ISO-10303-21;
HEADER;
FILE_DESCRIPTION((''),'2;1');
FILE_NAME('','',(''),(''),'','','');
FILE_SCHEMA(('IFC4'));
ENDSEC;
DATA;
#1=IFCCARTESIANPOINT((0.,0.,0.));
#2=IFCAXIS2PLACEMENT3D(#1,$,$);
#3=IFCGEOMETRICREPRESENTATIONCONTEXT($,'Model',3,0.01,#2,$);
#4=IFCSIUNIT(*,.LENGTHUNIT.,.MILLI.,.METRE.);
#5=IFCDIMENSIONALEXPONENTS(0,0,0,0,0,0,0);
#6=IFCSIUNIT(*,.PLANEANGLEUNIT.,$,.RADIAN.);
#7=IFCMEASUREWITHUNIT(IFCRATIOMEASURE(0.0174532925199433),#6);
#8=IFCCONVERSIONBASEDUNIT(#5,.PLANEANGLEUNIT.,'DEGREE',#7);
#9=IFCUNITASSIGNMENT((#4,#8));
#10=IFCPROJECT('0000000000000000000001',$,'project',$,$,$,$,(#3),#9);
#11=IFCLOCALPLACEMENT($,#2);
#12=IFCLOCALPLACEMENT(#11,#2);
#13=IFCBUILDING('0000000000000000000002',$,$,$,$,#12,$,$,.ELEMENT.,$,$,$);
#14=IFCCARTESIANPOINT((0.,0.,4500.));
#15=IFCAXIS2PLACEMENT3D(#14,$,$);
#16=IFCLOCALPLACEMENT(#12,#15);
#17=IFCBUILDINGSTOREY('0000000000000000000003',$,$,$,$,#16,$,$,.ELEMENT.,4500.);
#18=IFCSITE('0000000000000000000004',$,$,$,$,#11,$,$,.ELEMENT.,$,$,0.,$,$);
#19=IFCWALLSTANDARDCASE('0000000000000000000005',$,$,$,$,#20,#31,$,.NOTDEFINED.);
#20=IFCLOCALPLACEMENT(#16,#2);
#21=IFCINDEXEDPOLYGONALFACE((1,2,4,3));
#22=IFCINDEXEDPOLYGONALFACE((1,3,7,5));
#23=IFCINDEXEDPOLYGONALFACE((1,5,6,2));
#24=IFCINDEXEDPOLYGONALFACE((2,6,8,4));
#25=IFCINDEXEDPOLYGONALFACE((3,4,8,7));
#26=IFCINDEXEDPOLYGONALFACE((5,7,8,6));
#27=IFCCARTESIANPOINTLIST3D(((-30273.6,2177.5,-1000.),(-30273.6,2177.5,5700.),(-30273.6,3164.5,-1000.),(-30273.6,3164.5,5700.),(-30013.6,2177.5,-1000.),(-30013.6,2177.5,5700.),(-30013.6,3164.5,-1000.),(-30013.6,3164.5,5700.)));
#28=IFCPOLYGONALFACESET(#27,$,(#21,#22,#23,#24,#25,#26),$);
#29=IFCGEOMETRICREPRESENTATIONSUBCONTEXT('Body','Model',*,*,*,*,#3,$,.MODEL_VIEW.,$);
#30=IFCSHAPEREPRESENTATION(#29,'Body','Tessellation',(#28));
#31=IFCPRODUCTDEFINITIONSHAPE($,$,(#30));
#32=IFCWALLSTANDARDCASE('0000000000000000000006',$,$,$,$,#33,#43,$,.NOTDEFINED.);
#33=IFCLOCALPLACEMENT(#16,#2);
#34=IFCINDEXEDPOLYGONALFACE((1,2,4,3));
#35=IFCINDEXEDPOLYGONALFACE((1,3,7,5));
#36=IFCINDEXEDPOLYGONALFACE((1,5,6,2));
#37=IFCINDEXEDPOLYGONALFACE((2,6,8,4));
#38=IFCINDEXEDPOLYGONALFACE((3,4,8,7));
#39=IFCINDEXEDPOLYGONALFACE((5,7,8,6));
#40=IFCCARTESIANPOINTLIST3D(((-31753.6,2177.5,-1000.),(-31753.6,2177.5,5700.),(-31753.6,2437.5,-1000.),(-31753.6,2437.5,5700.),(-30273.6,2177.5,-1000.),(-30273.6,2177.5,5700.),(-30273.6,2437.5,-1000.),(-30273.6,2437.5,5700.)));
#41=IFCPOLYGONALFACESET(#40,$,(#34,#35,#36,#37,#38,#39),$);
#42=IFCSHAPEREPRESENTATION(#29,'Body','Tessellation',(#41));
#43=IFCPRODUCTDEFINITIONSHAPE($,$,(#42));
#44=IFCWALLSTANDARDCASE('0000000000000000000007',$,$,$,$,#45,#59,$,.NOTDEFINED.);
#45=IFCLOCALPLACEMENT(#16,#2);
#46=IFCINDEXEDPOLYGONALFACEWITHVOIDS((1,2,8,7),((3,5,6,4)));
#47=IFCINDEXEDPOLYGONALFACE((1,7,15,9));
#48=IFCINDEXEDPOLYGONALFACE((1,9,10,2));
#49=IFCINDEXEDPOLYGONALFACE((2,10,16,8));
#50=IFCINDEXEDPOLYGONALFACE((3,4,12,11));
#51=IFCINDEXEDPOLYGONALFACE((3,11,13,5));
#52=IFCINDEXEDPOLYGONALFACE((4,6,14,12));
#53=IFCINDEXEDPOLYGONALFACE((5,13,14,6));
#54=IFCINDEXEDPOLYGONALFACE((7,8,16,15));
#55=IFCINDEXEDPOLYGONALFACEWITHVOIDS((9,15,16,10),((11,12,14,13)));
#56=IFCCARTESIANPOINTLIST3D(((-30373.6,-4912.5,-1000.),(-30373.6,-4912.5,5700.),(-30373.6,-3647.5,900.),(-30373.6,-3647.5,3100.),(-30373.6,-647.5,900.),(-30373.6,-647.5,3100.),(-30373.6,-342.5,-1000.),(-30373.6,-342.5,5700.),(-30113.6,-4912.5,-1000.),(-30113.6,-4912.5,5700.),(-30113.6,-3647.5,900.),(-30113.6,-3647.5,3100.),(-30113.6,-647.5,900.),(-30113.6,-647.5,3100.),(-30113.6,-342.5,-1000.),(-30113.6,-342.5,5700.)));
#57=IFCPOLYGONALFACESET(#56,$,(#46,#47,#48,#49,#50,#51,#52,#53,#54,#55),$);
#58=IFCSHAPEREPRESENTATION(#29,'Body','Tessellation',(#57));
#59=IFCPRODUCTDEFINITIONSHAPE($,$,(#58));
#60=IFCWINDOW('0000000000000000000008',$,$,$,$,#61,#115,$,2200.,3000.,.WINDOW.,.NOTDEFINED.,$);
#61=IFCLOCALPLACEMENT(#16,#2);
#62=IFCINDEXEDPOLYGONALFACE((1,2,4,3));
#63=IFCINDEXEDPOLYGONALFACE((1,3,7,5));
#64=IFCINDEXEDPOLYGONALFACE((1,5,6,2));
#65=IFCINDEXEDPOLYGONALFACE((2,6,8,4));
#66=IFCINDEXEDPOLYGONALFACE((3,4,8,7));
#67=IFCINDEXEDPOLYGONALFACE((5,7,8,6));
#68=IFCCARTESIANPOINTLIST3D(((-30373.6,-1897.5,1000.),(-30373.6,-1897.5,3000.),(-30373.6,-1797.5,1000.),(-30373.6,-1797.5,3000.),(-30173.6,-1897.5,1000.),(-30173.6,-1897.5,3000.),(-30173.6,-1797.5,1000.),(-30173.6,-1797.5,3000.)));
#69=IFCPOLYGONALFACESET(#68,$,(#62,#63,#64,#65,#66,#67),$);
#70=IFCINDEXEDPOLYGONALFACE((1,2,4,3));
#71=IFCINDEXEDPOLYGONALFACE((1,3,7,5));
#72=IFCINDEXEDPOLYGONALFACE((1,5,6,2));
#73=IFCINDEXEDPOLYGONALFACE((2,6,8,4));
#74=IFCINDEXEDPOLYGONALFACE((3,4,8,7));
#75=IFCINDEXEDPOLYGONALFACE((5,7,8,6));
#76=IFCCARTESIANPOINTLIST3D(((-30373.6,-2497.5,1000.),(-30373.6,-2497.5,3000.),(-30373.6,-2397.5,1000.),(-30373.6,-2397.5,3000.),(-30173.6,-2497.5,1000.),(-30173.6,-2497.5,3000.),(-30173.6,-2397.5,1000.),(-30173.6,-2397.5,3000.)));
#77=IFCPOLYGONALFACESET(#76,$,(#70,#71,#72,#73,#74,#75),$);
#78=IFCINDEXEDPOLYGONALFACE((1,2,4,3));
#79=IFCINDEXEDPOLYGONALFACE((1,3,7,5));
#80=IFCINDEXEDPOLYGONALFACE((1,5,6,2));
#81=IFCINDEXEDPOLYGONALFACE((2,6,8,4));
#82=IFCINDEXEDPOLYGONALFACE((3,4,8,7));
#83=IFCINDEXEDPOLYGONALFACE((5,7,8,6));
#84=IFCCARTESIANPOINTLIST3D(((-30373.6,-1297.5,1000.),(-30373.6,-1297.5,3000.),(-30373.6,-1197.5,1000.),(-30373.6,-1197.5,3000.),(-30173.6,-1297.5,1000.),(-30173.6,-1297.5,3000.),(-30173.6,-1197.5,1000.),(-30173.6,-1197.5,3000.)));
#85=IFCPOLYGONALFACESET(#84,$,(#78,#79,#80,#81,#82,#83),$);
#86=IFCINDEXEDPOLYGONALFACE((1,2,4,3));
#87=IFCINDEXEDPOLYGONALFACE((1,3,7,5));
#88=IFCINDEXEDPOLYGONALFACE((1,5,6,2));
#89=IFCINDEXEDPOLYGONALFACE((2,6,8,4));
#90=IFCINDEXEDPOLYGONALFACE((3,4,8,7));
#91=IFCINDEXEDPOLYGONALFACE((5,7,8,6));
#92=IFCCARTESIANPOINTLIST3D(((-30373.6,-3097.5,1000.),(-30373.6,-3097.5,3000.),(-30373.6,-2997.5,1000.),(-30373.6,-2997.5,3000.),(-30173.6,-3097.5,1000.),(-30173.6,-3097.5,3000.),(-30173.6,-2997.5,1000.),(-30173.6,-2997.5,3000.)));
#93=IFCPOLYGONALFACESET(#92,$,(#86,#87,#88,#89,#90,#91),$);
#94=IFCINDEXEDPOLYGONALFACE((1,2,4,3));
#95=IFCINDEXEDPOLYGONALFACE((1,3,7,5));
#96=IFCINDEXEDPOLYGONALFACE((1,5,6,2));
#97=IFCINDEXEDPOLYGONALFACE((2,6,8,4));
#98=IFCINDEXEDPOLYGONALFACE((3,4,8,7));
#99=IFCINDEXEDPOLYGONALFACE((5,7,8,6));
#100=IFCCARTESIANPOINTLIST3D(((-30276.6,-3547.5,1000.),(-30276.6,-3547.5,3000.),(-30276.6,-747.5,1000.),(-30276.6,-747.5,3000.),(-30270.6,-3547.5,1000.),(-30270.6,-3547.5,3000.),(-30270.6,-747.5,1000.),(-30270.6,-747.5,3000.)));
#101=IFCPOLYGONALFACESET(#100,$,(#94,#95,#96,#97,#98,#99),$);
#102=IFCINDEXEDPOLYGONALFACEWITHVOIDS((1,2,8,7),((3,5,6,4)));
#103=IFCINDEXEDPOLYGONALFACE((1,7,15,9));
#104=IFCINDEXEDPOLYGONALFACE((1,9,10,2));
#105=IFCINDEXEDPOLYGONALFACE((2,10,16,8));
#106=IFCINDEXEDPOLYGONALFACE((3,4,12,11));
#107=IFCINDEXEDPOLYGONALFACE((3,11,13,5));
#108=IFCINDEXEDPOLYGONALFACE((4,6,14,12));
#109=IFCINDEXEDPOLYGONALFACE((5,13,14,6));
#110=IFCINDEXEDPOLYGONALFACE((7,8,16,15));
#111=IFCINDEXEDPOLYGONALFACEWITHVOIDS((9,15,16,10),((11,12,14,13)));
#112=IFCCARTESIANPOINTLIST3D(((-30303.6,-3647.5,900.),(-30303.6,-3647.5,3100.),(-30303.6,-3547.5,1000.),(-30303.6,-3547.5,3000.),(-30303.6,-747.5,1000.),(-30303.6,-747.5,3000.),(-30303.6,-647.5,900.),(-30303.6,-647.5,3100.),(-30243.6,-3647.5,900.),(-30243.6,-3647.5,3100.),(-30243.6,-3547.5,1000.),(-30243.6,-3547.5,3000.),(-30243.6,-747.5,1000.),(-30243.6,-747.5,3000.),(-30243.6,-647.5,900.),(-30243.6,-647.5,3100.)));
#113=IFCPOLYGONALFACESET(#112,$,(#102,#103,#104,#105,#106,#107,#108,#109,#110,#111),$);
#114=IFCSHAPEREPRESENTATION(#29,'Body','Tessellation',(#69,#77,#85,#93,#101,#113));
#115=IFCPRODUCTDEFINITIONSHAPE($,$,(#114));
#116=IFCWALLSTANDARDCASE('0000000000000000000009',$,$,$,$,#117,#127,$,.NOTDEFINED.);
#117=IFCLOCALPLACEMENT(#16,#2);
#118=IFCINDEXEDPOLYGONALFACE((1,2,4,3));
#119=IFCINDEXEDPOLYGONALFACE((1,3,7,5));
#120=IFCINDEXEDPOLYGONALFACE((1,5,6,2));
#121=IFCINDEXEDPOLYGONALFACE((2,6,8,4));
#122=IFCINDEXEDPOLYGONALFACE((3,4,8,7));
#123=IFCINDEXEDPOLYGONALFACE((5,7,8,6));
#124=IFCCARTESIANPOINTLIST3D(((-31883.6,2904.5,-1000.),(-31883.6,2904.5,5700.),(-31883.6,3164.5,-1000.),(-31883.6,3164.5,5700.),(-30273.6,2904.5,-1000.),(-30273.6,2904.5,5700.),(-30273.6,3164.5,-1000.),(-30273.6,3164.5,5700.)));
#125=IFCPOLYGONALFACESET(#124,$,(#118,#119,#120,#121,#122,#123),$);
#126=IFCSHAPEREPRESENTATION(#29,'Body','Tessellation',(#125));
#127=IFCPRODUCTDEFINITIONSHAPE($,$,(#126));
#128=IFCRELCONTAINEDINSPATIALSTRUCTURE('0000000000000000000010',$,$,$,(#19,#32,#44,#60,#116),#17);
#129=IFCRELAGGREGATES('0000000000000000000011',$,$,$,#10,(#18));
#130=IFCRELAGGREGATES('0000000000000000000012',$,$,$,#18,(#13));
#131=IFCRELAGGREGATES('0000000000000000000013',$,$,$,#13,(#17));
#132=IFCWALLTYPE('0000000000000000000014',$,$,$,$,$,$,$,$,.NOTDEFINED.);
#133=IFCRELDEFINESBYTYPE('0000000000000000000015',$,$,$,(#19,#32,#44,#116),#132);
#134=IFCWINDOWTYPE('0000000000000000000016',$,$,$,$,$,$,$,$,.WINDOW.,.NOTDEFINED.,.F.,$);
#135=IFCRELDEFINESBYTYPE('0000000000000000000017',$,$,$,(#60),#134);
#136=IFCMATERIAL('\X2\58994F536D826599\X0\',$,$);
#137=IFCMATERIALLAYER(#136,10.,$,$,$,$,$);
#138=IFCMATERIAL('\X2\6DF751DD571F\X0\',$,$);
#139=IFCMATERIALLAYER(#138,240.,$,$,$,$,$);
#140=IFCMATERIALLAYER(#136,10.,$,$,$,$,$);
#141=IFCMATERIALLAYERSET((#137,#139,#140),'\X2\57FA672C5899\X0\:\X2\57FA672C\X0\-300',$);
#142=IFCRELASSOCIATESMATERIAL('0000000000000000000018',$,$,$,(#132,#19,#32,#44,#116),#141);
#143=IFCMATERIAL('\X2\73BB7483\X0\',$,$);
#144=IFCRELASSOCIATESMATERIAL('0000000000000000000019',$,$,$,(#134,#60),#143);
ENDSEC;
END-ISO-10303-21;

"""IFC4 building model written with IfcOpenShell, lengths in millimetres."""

from ifc_helpers import new_model, entity, si_unit, converted_unit, frame, frame_2d, origin, origin_2d_with_axis, place, context, subcontext, project, spatial, polyline, rectangle, outline, extrude, source, transform, mapped, material, layer, layer_set, layer_usage, type_object, type_shapes, element, fill, save


model = new_model("IFC4")

# Units and contexts
model_context = context("Model", 3, precision=0.01, world=origin())
body_context = subcontext(model_context, "Body", "Model", "MODEL_VIEW")
ifc_project = project(units=[si_unit("LENGTHUNIT", "METRE", prefix="MILLI"), converted_unit("PLANEANGLEUNIT", "DEGREE", entity("IfcRatioMeasure", 0.0174532925199433), si_unit("PLANEANGLEUNIT", "RADIAN"), dimensions=[0, 0, 0, 0, 0, 0, 0])], contexts=[model_context])

# Site, building, storey
site_placement = place(None, origin())
site = spatial("IfcSite", under=ifc_project, at=site_placement, CompositionType="ELEMENT", RefElevation=0.0)
building_placement = place(site_placement, origin())
building = spatial("IfcBuilding", under=site, at=building_placement, CompositionType="ELEMENT")
storey_placement = place(building_placement, frame((0.0, 0.0, 4500.0)))
storey = spatial("IfcBuildingStorey", under=building, at=storey_placement, CompositionType="ELEMENT", Elevation=4500.0)

# Shared definitions
ifc_material_1 = material(Name="混凝土")

# Shared definitions
ifc_material_2 = material(Name="墙体涂料")
ifc_layer_1 = layer(ifc_material_2, 10.0)
ifc_layer_2 = layer(ifc_material_1, 240.0)
ifc_layer_3 = layer(ifc_material_2, 10.0)
ifc_layer_set_1 = layer_set([ifc_layer_1, ifc_layer_2, ifc_layer_3], Name="基本墙:基本-300")
wall_type = type_object("IfcWallType", PredefinedType="NOTDEFINED", material=ifc_layer_set_1)
ifc_material_3 = material(Name="玻璃")

# Walls
ifc_layer_usage_1 = layer_usage(ifc_layer_set_1, "AXIS2", "NEGATIVE", 130.0)
wall_1_placement = place(storey_placement, frame((-30143.6, 3164.5, -1000.0), z_axis=(0.0, 0.0, 1.0), x_axis=(0.0, -1.0, 0.0)))
element("IfcWallStandardCase", 1, at=wall_1_placement, inside=storey, type_object=wall_type, material=ifc_layer_usage_1, PredefinedType="NOTDEFINED", context=body_context, shape_type="SweptSolid", body=[
    extrude(rectangle(XDim=987.0, YDim=260.0, at=frame_2d((493.5, 0.0), x_axis=(-1.0, 0.0))), origin(), (0.0, 0.0, 1.0), 6700.0),
])
ifc_layer_usage_2 = layer_usage(ifc_layer_set_1, "AXIS2", "NEGATIVE", 130.0)
wall_2_placement = place(storey_placement, frame((-30273.6, 2307.5, -1000.0), z_axis=(0.0, 0.0, 1.0), x_axis=(-1.0, 0.0, 0.0)))
element("IfcWallStandardCase", 2, at=wall_2_placement, inside=storey, type_object=wall_type, material=ifc_layer_usage_2, PredefinedType="NOTDEFINED", context=body_context, shape_type="SweptSolid", body=[
    extrude(rectangle(XDim=1480.0, YDim=260.0, at=frame_2d((740.0, 0.0), x_axis=(-1.0, 0.0))), origin(), (0.0, 0.0, 1.0), 6700.0),
])

# Wall, opening, window
ifc_layer_usage_3 = layer_usage(ifc_layer_set_1, "AXIS2", "NEGATIVE", 130.0)
wall_3_placement = place(storey_placement, frame((-30243.6, -342.5, -1000.0), z_axis=(0.0, 0.0, 1.0), x_axis=(0.0, -1.0, 0.0)))
wall_3 = element("IfcWallStandardCase", 3, at=wall_3_placement, inside=storey, type_object=wall_type, material=ifc_layer_usage_3, PredefinedType="NOTDEFINED", context=body_context, shape_type="SweptSolid", body=[
    extrude(rectangle(XDim=4570.0, YDim=260.0, at=frame_2d((2285.0, 0.0), x_axis=(-1.0, 0.0))), origin(), (0.0, 0.0, 1.0), 6700.0),
])
opening_1_placement = place(wall_3_placement, frame((305.0, -130.0, 1900.0)))
opening_1 = element("IfcOpeningElement", 4, at=opening_1_placement, cuts=wall_3, PredefinedType="OPENING", context=body_context, shape_type="SweptSolid", body=[
    extrude(rectangle(XDim=2200.0, YDim=3000.0, at=frame_2d((1100.0, 1500.0), x_axis=(1.0, 0.0))), frame((0.0, 0.0, 0.0), z_axis=(0.0, 1.0, 0.0), x_axis=(0.0, 0.0, 1.0)), (0.0, 0.0, 1.0), 260.0),
])
window_type = type_object("IfcWindowType", ParameterTakesPrecedence=False, PartitioningType="NOTDEFINED", PredefinedType="WINDOW", material=ifc_material_3)
shared_shape_1 = source(origin(), body_context, "Body", "SweptSolid", [
    extrude(rectangle(XDim=100.0, YDim=200.0, at=origin_2d_with_axis()), frame((1200.0, 100.0, 100.0), z_axis=(0.0, 0.0, 1.0), x_axis=(-1.0, 0.0, 0.0)), (0.0, 0.0, 1.0), 2000.0),
    extrude(rectangle(XDim=100.0, YDim=200.0, at=origin_2d_with_axis()), frame((1800.0, 100.0, 100.0), z_axis=(0.0, 0.0, 1.0), x_axis=(-1.0, 0.0, 0.0)), (0.0, 0.0, 1.0), 2000.0),
    extrude(rectangle(XDim=100.0, YDim=200.0, at=origin_2d_with_axis()), frame((600.0, 100.0, 100.0), z_axis=(0.0, 0.0, 1.0), x_axis=(-1.0, 0.0, 0.0)), (0.0, 0.0, 1.0), 2000.0),
    extrude(rectangle(XDim=100.0, YDim=200.0, at=origin_2d_with_axis()), frame((2400.0, 100.0, 100.0), z_axis=(0.0, 0.0, 1.0), x_axis=(-1.0, 0.0, 0.0)), (0.0, 0.0, 1.0), 2000.0),
    extrude(rectangle(XDim=6.0, YDim=2800.0, at=frame_2d((0.0, 0.0), x_axis=(1.0, 0.0))), frame((1500.0, 100.0, 100.0), z_axis=(0.0, 0.0, 1.0), x_axis=(0.0, -1.0, 0.0)), (0.0, 0.0, 1.0), 2000.0),
    extrude(outline(polyline([(-1500.0, -1100.0), (1500.0, -1100.0), (1500.0, 1100.0), (-1500.0, 1100.0), (-1500.0, -1100.0)]), holes=[polyline([(-1400.0, -1000.0), (-1400.0, 1000.0), (1400.0, 1000.0), (1400.0, -1000.0), (-1400.0, -1000.0)])]), frame((1500.0, 70.0, 1100.0), z_axis=(0.0, 1.0, 0.0), x_axis=(1.0, 0.0, 0.0)), (0.0, 0.0, 1.0), 60.0),
])
type_shapes(window_type, [shared_shape_1])
window_placement = place(opening_1_placement, origin())
window = element("IfcWindow", 5, at=window_placement, inside=storey, type_object=window_type, material=ifc_material_3, OverallHeight=2200.0, OverallWidth=3000.0, PartitioningType="NOTDEFINED", PredefinedType="WINDOW", context=body_context, shape_type="MappedRepresentation", body=[
    mapped(shared_shape_1, transform((0.0, 0.0, 0.0), scale=1.0)),
])
fill(opening_1, window)

# Wall
ifc_layer_usage_4 = layer_usage(ifc_layer_set_1, "AXIS2", "NEGATIVE", 130.0)
wall_4_placement = place(storey_placement, frame((-31883.6, 3034.5, -1000.0)))
element("IfcWallStandardCase", 6, at=wall_4_placement, inside=storey, type_object=wall_type, material=ifc_layer_usage_4, PredefinedType="NOTDEFINED", context=body_context, shape_type="SweptSolid", body=[
    extrude(rectangle(XDim=1610.0, YDim=260.0, at=frame_2d((805.0, 0.0), x_axis=(-1.0, 0.0))), origin(), (0.0, 0.0, 1.0), 6700.0),
])

save(model, "model.ifc")
